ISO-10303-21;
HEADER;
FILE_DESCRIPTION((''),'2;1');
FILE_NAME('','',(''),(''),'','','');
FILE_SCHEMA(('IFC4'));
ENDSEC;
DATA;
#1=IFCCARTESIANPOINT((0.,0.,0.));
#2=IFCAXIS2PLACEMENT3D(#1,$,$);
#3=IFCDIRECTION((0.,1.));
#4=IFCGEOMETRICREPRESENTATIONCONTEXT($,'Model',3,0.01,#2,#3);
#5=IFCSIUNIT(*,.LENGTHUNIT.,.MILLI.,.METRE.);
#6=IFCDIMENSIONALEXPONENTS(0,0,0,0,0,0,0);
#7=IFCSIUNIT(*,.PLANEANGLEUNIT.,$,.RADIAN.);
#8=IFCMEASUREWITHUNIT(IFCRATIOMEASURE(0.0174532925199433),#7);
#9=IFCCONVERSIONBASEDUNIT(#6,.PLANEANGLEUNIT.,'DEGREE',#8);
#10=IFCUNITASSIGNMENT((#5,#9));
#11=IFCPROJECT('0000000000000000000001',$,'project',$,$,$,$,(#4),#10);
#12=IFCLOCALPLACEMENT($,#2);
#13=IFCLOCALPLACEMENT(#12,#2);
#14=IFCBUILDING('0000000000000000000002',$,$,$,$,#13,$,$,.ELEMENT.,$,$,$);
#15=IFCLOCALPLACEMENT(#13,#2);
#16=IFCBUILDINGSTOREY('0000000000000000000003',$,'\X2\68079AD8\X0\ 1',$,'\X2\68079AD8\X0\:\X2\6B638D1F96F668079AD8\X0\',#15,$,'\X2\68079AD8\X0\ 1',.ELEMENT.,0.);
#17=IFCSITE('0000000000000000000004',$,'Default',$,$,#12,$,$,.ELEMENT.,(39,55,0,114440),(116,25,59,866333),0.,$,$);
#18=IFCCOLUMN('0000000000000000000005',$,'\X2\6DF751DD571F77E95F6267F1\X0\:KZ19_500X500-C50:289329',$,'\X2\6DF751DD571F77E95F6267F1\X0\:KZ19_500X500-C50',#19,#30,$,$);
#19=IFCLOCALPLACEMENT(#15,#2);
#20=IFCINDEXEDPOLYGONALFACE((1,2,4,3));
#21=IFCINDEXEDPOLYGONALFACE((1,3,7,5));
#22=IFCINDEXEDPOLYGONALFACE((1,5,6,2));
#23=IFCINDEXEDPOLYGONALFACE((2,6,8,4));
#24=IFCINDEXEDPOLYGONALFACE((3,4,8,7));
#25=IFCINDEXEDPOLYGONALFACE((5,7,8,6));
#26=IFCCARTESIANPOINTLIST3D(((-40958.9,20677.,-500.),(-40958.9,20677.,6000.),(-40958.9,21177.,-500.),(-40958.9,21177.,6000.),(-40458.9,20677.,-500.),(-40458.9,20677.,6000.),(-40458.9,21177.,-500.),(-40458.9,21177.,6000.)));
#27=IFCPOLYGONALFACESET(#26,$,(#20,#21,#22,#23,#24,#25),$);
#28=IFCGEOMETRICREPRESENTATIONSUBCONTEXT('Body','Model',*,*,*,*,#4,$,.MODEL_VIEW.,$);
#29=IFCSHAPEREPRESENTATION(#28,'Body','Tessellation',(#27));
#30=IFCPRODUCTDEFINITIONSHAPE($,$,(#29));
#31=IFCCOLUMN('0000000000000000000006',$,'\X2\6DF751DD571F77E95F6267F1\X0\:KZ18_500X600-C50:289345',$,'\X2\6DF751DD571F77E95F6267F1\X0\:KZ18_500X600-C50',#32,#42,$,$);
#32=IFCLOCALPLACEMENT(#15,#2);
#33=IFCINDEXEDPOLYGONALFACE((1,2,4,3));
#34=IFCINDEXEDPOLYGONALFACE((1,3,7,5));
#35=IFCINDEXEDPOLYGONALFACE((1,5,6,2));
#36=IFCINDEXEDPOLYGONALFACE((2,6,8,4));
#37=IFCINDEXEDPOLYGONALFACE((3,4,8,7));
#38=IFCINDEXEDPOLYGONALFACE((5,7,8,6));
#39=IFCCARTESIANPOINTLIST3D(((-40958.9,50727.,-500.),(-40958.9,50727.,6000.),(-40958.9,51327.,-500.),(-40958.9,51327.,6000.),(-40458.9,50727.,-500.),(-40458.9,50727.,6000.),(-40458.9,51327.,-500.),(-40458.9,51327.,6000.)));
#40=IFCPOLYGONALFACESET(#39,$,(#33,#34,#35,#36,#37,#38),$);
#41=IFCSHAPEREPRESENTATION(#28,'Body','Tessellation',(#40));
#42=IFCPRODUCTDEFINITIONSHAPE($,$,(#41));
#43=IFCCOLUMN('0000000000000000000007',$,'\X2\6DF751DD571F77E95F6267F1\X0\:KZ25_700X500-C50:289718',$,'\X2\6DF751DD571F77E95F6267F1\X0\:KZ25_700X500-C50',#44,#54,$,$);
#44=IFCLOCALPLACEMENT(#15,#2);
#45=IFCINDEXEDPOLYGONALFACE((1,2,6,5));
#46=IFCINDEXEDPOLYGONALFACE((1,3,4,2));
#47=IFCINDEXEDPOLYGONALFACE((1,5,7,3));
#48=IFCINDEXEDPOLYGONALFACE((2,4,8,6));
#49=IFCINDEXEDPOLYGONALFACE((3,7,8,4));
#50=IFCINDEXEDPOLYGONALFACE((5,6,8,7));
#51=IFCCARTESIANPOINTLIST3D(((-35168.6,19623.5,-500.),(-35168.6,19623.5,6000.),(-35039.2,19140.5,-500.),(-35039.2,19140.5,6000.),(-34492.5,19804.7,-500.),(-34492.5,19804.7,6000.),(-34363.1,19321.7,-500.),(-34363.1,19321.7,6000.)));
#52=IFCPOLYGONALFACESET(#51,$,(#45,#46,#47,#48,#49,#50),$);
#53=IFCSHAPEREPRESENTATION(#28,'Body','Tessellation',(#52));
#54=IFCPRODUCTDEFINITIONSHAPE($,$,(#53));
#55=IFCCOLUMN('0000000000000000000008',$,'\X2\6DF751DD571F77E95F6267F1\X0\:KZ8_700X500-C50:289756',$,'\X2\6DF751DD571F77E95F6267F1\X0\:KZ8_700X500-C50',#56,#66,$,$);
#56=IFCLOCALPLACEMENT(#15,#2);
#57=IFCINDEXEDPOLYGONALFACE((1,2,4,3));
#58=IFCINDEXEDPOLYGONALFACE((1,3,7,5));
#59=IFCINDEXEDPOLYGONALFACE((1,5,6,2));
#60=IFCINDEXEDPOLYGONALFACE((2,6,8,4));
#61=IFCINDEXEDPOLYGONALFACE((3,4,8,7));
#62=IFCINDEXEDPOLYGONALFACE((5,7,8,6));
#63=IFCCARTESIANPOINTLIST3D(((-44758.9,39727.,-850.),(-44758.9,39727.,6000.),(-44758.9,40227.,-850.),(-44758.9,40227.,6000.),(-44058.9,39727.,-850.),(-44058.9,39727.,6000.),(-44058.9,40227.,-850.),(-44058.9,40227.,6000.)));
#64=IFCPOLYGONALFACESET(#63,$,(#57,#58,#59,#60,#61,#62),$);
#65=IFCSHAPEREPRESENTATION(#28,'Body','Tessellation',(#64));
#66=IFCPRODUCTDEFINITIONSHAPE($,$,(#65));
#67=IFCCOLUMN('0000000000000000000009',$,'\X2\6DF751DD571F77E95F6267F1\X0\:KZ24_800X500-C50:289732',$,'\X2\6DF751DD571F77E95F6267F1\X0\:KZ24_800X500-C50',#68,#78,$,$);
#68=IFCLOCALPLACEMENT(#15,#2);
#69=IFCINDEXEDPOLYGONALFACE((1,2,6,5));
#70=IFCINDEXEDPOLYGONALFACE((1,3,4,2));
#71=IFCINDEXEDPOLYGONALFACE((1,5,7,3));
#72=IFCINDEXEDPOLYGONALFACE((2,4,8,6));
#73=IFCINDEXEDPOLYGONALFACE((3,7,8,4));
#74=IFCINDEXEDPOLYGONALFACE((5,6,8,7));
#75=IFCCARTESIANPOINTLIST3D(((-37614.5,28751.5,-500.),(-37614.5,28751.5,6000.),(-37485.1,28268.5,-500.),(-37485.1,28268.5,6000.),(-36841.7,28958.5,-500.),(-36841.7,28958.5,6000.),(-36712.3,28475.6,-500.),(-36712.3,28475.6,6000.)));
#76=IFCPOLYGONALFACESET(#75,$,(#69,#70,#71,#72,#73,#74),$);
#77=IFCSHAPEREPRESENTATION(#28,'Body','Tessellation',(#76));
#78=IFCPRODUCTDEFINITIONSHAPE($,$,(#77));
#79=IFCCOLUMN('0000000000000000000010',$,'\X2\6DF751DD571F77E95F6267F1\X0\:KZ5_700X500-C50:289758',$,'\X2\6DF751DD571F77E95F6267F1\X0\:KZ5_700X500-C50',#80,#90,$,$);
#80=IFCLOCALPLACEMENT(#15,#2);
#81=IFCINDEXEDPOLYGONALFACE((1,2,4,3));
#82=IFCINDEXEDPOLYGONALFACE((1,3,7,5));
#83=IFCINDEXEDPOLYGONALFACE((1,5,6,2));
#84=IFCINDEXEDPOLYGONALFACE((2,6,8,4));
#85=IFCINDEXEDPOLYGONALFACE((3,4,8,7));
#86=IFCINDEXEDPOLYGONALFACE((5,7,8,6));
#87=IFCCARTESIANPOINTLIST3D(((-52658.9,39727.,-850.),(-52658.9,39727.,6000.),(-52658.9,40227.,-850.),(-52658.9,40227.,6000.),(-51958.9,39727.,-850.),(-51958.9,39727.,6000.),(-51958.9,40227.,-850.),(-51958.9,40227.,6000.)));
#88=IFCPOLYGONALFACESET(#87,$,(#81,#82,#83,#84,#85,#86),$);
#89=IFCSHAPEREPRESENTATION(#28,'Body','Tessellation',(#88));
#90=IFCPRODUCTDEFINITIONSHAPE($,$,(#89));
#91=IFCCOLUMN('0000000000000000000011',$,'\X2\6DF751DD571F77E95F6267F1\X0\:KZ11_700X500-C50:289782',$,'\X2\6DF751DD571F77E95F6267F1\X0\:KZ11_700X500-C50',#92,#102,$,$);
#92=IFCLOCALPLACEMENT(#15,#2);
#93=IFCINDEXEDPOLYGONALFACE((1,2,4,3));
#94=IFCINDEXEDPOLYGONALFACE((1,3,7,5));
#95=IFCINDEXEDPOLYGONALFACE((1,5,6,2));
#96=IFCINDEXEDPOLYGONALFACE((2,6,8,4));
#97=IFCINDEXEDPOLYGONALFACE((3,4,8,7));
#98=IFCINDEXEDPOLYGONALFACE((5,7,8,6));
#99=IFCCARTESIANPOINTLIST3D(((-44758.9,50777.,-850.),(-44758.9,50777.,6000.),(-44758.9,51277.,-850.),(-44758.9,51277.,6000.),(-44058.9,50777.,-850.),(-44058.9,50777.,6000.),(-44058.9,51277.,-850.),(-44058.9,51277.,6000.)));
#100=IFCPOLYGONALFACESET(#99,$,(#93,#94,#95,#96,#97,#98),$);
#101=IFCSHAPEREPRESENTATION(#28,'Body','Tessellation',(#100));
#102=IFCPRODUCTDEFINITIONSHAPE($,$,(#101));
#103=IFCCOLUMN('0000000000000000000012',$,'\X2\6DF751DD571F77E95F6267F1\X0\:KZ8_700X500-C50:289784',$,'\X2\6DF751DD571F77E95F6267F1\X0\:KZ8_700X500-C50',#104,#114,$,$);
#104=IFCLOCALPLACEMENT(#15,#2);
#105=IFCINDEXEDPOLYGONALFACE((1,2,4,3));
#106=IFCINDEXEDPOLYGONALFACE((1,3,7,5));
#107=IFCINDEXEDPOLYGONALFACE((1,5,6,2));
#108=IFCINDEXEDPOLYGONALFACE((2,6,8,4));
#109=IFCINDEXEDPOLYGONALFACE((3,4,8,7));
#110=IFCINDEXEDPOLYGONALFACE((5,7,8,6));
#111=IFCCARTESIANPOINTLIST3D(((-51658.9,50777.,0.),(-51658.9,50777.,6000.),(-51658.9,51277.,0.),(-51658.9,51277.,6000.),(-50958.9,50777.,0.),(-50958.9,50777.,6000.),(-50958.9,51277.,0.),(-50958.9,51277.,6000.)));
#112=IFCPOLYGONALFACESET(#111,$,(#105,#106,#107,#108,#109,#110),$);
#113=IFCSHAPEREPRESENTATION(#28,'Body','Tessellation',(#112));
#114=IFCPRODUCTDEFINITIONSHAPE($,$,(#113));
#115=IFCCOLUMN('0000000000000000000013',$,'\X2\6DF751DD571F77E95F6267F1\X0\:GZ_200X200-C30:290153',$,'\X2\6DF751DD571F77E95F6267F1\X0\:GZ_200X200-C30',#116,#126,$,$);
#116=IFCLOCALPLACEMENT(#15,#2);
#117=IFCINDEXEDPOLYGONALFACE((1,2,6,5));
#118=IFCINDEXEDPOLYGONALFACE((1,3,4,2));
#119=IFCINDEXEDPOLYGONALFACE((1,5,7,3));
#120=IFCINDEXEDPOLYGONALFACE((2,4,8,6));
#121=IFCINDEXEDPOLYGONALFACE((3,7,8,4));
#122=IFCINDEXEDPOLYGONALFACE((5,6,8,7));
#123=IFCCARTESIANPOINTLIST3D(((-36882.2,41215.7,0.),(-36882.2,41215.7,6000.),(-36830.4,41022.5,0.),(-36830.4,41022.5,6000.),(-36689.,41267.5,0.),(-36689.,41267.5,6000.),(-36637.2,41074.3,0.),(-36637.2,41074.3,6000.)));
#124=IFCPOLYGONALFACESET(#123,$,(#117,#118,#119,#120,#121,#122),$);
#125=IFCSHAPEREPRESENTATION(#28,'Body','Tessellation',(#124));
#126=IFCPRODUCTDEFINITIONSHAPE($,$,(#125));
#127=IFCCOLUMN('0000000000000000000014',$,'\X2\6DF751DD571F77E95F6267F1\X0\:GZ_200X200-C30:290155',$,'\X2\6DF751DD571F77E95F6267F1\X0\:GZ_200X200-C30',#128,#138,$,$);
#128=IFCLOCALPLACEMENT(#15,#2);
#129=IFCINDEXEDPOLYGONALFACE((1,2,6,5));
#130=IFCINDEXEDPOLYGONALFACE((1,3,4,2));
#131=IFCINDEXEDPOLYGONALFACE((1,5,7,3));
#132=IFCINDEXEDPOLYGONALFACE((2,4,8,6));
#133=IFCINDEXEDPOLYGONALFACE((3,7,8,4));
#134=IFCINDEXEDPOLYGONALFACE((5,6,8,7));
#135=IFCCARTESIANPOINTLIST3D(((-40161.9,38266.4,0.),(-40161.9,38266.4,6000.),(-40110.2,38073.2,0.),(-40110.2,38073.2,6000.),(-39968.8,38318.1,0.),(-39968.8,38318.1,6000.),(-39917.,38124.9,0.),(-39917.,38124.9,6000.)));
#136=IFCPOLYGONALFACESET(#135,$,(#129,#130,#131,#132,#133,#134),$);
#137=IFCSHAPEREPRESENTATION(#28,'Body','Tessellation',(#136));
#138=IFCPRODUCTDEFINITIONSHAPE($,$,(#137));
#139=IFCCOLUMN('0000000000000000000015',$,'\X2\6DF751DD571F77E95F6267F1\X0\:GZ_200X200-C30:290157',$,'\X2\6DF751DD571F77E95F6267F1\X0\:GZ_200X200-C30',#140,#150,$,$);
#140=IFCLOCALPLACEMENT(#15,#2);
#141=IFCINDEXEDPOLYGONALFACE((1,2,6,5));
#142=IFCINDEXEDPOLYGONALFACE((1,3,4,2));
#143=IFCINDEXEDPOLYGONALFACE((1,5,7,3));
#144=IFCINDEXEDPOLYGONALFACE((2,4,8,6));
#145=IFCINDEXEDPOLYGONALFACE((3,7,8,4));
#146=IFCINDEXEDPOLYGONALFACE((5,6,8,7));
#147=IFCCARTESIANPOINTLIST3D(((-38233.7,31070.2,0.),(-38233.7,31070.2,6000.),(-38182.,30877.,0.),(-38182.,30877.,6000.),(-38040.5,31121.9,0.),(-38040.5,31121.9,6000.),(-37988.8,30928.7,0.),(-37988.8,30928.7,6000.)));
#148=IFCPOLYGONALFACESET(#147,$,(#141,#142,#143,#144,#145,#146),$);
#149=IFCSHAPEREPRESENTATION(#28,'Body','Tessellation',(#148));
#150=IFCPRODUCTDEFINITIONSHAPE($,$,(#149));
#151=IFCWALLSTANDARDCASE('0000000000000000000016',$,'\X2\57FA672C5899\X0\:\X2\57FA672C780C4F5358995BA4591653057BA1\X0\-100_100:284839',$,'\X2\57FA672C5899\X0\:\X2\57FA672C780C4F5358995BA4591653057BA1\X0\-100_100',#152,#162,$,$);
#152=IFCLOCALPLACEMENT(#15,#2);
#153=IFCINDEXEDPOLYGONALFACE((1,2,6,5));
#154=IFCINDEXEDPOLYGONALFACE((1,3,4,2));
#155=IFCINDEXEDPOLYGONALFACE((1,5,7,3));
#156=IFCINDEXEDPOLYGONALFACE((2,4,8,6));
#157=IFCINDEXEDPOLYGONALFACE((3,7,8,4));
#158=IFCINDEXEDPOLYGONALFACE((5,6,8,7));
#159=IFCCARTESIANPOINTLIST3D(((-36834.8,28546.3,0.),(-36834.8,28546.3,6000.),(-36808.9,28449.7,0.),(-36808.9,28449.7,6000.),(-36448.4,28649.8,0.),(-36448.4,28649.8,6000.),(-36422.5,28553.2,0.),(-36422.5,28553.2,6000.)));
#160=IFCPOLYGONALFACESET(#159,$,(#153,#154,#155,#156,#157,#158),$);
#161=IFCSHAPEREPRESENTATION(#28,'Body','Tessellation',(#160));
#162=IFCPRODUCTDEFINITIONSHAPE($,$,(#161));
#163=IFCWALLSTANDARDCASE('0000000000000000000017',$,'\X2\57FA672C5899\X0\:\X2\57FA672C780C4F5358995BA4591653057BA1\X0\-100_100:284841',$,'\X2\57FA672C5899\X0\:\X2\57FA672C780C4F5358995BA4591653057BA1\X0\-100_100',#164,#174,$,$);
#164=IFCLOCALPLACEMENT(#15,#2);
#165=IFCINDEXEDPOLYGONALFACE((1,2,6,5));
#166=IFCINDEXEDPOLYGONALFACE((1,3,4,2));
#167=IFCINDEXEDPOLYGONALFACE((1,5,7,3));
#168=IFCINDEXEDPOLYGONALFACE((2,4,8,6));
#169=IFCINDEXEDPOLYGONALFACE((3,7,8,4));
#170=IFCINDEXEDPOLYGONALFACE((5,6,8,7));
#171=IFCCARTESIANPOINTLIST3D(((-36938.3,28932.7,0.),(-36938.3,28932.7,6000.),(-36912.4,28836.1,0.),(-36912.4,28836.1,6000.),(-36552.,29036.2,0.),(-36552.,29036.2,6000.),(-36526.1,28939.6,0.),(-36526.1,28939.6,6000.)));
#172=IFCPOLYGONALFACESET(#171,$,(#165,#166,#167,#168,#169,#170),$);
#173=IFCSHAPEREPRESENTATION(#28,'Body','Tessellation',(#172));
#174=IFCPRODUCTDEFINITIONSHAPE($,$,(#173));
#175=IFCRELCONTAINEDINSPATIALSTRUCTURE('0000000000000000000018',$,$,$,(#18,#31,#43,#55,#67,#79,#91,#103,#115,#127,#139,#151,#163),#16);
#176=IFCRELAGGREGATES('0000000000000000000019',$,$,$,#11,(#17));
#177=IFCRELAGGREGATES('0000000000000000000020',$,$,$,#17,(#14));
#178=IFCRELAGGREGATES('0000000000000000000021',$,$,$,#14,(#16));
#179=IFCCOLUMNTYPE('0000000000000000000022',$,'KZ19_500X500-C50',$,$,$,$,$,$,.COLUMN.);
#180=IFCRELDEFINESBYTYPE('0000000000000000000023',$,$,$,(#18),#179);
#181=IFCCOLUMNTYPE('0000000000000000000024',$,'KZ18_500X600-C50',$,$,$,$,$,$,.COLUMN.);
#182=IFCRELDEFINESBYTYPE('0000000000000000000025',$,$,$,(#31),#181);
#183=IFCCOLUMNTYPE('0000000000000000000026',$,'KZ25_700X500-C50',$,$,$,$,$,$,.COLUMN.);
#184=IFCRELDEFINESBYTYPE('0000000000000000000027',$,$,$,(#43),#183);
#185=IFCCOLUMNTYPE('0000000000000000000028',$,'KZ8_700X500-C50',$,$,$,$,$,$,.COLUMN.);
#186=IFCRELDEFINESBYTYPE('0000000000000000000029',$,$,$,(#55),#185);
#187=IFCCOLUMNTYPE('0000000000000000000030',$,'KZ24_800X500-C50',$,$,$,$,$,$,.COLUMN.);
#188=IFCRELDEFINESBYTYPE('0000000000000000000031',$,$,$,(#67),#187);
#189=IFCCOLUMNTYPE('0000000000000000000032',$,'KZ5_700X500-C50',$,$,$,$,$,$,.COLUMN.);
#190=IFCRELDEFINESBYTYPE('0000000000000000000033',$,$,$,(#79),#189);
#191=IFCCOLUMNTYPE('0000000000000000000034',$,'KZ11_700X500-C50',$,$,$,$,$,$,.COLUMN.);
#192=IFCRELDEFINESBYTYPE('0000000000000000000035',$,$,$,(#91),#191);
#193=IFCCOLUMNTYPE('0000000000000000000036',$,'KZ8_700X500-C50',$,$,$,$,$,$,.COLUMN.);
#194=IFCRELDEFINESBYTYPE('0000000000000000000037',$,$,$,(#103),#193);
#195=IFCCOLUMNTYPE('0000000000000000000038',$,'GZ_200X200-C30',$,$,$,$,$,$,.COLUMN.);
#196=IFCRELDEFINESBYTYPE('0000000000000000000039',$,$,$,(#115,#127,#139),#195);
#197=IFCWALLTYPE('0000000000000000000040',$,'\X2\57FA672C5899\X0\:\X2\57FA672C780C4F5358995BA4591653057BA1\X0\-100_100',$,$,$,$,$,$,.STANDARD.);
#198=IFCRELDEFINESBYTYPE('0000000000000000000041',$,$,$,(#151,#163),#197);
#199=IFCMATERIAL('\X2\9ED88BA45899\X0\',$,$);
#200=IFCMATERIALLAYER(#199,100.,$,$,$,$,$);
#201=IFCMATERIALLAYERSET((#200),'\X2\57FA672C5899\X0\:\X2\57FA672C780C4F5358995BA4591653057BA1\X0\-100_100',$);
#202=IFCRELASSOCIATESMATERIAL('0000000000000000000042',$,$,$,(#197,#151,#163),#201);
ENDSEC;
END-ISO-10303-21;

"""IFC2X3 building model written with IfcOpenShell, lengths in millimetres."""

from ifc_helpers import new_model, entity, si_unit, converted_unit, direction, frame, frame_2d, origin, origin_2d_with_axis, place, context, subcontext, project, spatial, rectangle, extrude, source, transform, mapped, material, layer, layer_set, layer_usage, type_object, type_shapes, element, save


model = new_model("IFC2X3")

# Units and contexts
model_context = context("Model", 3, precision=0.01, world=origin(), true_north=direction((0.0, 1.0)))
body_context = subcontext(model_context, "Body", "Model", "MODEL_VIEW")
ifc_project = project(units=[si_unit("LENGTHUNIT", "METRE", prefix="MILLI"), converted_unit("PLANEANGLEUNIT", "DEGREE", entity("IfcRatioMeasure", 0.0174532925199433), si_unit("PLANEANGLEUNIT", "RADIAN"), dimensions=[0, 0, 0, 0, 0, 0, 0])], contexts=[model_context])

# Site, building, storey
site_placement = place(None, origin())
site = spatial("IfcSite", under=ifc_project, at=site_placement, Name="Default", CompositionType="ELEMENT", RefLatitude=(39, 55, 0, 114440), RefLongitude=(116, 25, 59, 866333), RefElevation=0.0)
building_placement = place(site_placement, origin())
building = spatial("IfcBuilding", under=site, at=building_placement, CompositionType="ELEMENT")
storey_placement = place(building_placement, origin())
storey = spatial("IfcBuildingStorey", under=building, at=storey_placement, Name="标高 1", ObjectType="标高:正负零标高", LongName="标高 1", CompositionType="ELEMENT", Elevation=0.0)

# Columns
column_type_1 = type_object("IfcColumnType", Name="KZ19_500X500-C50", PredefinedType="COLUMN")
shared_shape_1 = source(origin(), body_context, "Body", "SweptSolid", [
    extrude(rectangle(XDim=500.0, YDim=500.0, at=origin_2d_with_axis()), frame((0.0, 0.0, -500.0), z_axis=(0.0, 0.0, 1.0), x_axis=(0.0, -1.0, 0.0)), (0.0, 0.0, 1.0), 6500.0),
])
type_shapes(column_type_1, [shared_shape_1])
column_1_placement = place(building_placement, frame((-40708.9, 20927.0, 0.0)))
element("IfcColumn", 1, at=column_1_placement, inside=storey, type_object=column_type_1, Name="混凝土矩形柱:KZ19_500X500-C50:289329", ObjectType="混凝土矩形柱:KZ19_500X500-C50", context=body_context, shape_type="MappedRepresentation", body=[
    mapped(shared_shape_1, transform((0.0, 0.0, 0.0), scale=1.0)),
])
column_type_2 = type_object("IfcColumnType", Name="KZ18_500X600-C50", PredefinedType="COLUMN")
shared_shape_2 = source(origin(), body_context, "Body", "SweptSolid", [
    extrude(rectangle(XDim=600.0, YDim=500.0, at=origin_2d_with_axis()), frame((0.0, 0.0, -500.0), z_axis=(0.0, 0.0, 1.0), x_axis=(0.0, -1.0, 0.0)), (0.0, 0.0, 1.0), 6500.0),
])
type_shapes(column_type_2, [shared_shape_2])
column_2_placement = place(building_placement, frame((-40708.9, 51027.0, 0.0)))
element("IfcColumn", 2, at=column_2_placement, inside=storey, type_object=column_type_2, Name="混凝土矩形柱:KZ18_500X600-C50:289345", ObjectType="混凝土矩形柱:KZ18_500X600-C50", context=body_context, shape_type="MappedRepresentation", body=[
    mapped(shared_shape_2, transform((0.0, 0.0, 0.0), scale=1.0)),
])
column_type_3 = type_object("IfcColumnType", Name="KZ25_700X500-C50", PredefinedType="COLUMN")
shared_shape_3 = source(origin(), body_context, "Body", "SweptSolid", [
    extrude(rectangle(XDim=500.0, YDim=700.0, at=origin_2d_with_axis()), frame((0.0, 0.0, -500.0), z_axis=(0.0, 0.0, 1.0), x_axis=(0.0, -1.0, 0.0)), (0.0, 0.0, 1.0), 6500.0),
])
type_shapes(column_type_3, [shared_shape_3])
column_3_placement = place(building_placement, frame((-34765.9, 19472.6, 0.0), z_axis=(0.0, 0.0, 1.0), x_axis=(0.965926, 0.258819, 0.0)))
element("IfcColumn", 3, at=column_3_placement, inside=storey, type_object=column_type_3, Name="混凝土矩形柱:KZ25_700X500-C50:289718", ObjectType="混凝土矩形柱:KZ25_700X500-C50", context=body_context, shape_type="MappedRepresentation", body=[
    mapped(shared_shape_3, transform((0.0, 0.0, 0.0), scale=1.0)),
])
column_type_4 = type_object("IfcColumnType", Name="KZ8_700X500-C50", PredefinedType="COLUMN")
shared_shape_4 = source(origin(), body_context, "Body", "SweptSolid", [
    extrude(rectangle(XDim=500.0, YDim=700.0, at=origin_2d_with_axis()), frame((0.0, 0.0, -850.0), z_axis=(0.0, 0.0, 1.0), x_axis=(0.0, -1.0, 0.0)), (0.0, 0.0, 1.0), 6850.0),
])
type_shapes(column_type_4, [shared_shape_4])
column_4_placement = place(building_placement, frame((-44408.9, 39977.0, 0.0)))
element("IfcColumn", 4, at=column_4_placement, inside=storey, type_object=column_type_4, Name="混凝土矩形柱:KZ8_700X500-C50:289756", ObjectType="混凝土矩形柱:KZ8_700X500-C50", context=body_context, shape_type="MappedRepresentation", body=[
    mapped(shared_shape_4, transform((0.0, 0.0, 0.0), scale=1.0)),
])
column_type_5 = type_object("IfcColumnType", Name="KZ24_800X500-C50", PredefinedType="COLUMN")
shared_shape_5 = source(origin(), body_context, "Body", "SweptSolid", [
    extrude(rectangle(XDim=500.0, YDim=800.0, at=origin_2d_with_axis()), frame((0.0, 0.0, -500.0), z_axis=(0.0, 0.0, 1.0), x_axis=(0.0, -1.0, 0.0)), (0.0, 0.0, 1.0), 6500.0),
])
type_shapes(column_type_5, [shared_shape_5])
column_5_placement = place(building_placement, frame((-37163.4, 28613.5, 0.0), z_axis=(0.0, 0.0, 1.0), x_axis=(0.965926, 0.258819, 0.0)))
element("IfcColumn", 5, at=column_5_placement, inside=storey, type_object=column_type_5, Name="混凝土矩形柱:KZ24_800X500-C50:289732", ObjectType="混凝土矩形柱:KZ24_800X500-C50", context=body_context, shape_type="MappedRepresentation", body=[
    mapped(shared_shape_5, transform((0.0, 0.0, 0.0), scale=1.0)),
])
column_type_6 = type_object("IfcColumnType", Name="KZ5_700X500-C50", PredefinedType="COLUMN")
shared_shape_6 = source(origin(), body_context, "Body", "SweptSolid", [
    extrude(rectangle(XDim=500.0, YDim=700.0, at=origin_2d_with_axis()), frame((0.0, 0.0, -850.0), z_axis=(0.0, 0.0, 1.0), x_axis=(0.0, -1.0, 0.0)), (0.0, 0.0, 1.0), 6850.0),
])
type_shapes(column_type_6, [shared_shape_6])
column_6_placement = place(building_placement, frame((-52308.9, 39977.0, 0.0)))
element("IfcColumn", 6, at=column_6_placement, inside=storey, type_object=column_type_6, Name="混凝土矩形柱:KZ5_700X500-C50:289758", ObjectType="混凝土矩形柱:KZ5_700X500-C50", context=body_context, shape_type="MappedRepresentation", body=[
    mapped(shared_shape_6, transform((0.0, 0.0, 0.0), scale=1.0)),
])
column_type_7 = type_object("IfcColumnType", Name="KZ11_700X500-C50", PredefinedType="COLUMN")
shared_shape_7 = source(origin(), body_context, "Body", "SweptSolid", [
    extrude(rectangle(XDim=500.0, YDim=700.0, at=origin_2d_with_axis()), frame((0.0, 0.0, -850.0), z_axis=(0.0, 0.0, 1.0), x_axis=(0.0, -1.0, 0.0)), (0.0, 0.0, 1.0), 6850.0),
])
type_shapes(column_type_7, [shared_shape_7])
column_7_placement = place(building_placement, frame((-44408.9, 51027.0, 0.0)))
element("IfcColumn", 7, at=column_7_placement, inside=storey, type_object=column_type_7, Name="混凝土矩形柱:KZ11_700X500-C50:289782", ObjectType="混凝土矩形柱:KZ11_700X500-C50", context=body_context, shape_type="MappedRepresentation", body=[
    mapped(shared_shape_7, transform((0.0, 0.0, 0.0), scale=1.0)),
])
column_type_8 = type_object("IfcColumnType", Name="KZ8_700X500-C50", PredefinedType="COLUMN")
shared_shape_8 = source(origin(), body_context, "Body", "SweptSolid", [
    extrude(rectangle(XDim=500.0, YDim=700.0, at=origin_2d_with_axis()), frame((0.0, 0.0, 0.0), z_axis=(0.0, 0.0, 1.0), x_axis=(0.0, -1.0, 0.0)), (0.0, 0.0, 1.0), 6000.0),
])
type_shapes(column_type_8, [shared_shape_8])
column_8_placement = place(building_placement, frame((-51308.9, 51027.0, 0.0), z_axis=(0.0, 0.0, 1.0), x_axis=(-1.0, 0.0, 0.0)))
element("IfcColumn", 8, at=column_8_placement, inside=storey, type_object=column_type_8, Name="混凝土矩形柱:KZ8_700X500-C50:289784", ObjectType="混凝土矩形柱:KZ8_700X500-C50", context=body_context, shape_type="MappedRepresentation", body=[
    mapped(shared_shape_8, transform((0.0, 0.0, 0.0), scale=1.0)),
])
column_type_9 = type_object("IfcColumnType", Name="GZ_200X200-C30", PredefinedType="COLUMN")
shared_shape_9 = source(origin(), body_context, "Body", "SweptSolid", [
    extrude(rectangle(XDim=200.0, YDim=200.0, at=origin_2d_with_axis()), frame((0.0, 0.0, 0.0), z_axis=(0.0, 0.0, 1.0), x_axis=(0.0, -1.0, 0.0)), (0.0, 0.0, 1.0), 6000.0),
])
type_shapes(column_type_9, [shared_shape_9])
for number, where, z_axis, x_axis, name in (
    (9, (-36759.7, 41145.0, 0.0), (0.0, 0.0, 1.0), (0.965926, 0.258819, 0.0), "混凝土矩形柱:GZ_200X200-C30:290153"),
    (10, (-40039.5, 38195.7, 0.0), (0.0, 0.0, 1.0), (0.965926, 0.258819, 0.0), "混凝土矩形柱:GZ_200X200-C30:290155"),
    (11, (-38111.2, 30999.4, 0.0), (0.0, 0.0, 1.0), (0.965926, 0.258819, 0.0), "混凝土矩形柱:GZ_200X200-C30:290157"),
):
    element("IfcColumn", number, at=place(building_placement, frame(where, z_axis=z_axis, x_axis=x_axis)), inside=storey, type_object=column_type_9, Name=name, ObjectType="混凝土矩形柱:GZ_200X200-C30", context=body_context, shape_type="MappedRepresentation", body=[
        mapped(shared_shape_9, transform((0.0, 0.0, 0.0), scale=1.0)),
    ])

# Walls
ifc_material = material(Name="默认墙")
ifc_layer_1 = layer(ifc_material, 100.0)
ifc_layer_set_1 = layer_set([ifc_layer_1], Name="基本墙:基本砌体墙室外包管-100_100")
ifc_layer_usage_1 = layer_usage(ifc_layer_set_1, "AXIS2", "NEGATIVE", 50.0)
wall_type_1 = type_object("IfcWallType", Name="基本墙:基本砌体墙室外包管-100_100", PredefinedType="STANDARD", material=ifc_layer_set_1)
wall_1_placement = place(building_placement, frame((-36821.8, 28498.0, 0.0), z_axis=(0.0, 0.0, 1.0), x_axis=(0.965926, 0.258819, 0.0)))
element("IfcWallStandardCase", 12, at=wall_1_placement, inside=storey, type_object=wall_type_1, material=ifc_layer_usage_1, Name="基本墙:基本砌体墙室外包管-100_100:284839", ObjectType="基本墙:基本砌体墙室外包管-100_100", context=body_context, shape_type="SweptSolid", body=[
    extrude(rectangle(XDim=400.0, YDim=100.0, at=frame_2d((200.0, 0.0), x_axis=(-1.0, 0.0))), origin(), (0.0, 0.0, 1.0), 6000.0),
])
ifc_layer_usage_2 = layer_usage(ifc_layer_set_1, "AXIS2", "NEGATIVE", 50.0)
wall_2_placement = place(building_placement, frame((-36925.4, 28884.4, 0.0), z_axis=(0.0, 0.0, 1.0), x_axis=(0.965926, 0.258819, 0.0)))
element("IfcWallStandardCase", 13, at=wall_2_placement, inside=storey, type_object=wall_type_1, material=ifc_layer_usage_2, Name="基本墙:基本砌体墙室外包管-100_100:284841", ObjectType="基本墙:基本砌体墙室外包管-100_100", context=body_context, shape_type="SweptSolid", body=[
    extrude(rectangle(XDim=400.0, YDim=100.0, at=frame_2d((200.0, 0.0), x_axis=(-1.0, 0.0))), origin(), (0.0, 0.0, 1.0), 6000.0),
])

save(model, "model.ifc")
